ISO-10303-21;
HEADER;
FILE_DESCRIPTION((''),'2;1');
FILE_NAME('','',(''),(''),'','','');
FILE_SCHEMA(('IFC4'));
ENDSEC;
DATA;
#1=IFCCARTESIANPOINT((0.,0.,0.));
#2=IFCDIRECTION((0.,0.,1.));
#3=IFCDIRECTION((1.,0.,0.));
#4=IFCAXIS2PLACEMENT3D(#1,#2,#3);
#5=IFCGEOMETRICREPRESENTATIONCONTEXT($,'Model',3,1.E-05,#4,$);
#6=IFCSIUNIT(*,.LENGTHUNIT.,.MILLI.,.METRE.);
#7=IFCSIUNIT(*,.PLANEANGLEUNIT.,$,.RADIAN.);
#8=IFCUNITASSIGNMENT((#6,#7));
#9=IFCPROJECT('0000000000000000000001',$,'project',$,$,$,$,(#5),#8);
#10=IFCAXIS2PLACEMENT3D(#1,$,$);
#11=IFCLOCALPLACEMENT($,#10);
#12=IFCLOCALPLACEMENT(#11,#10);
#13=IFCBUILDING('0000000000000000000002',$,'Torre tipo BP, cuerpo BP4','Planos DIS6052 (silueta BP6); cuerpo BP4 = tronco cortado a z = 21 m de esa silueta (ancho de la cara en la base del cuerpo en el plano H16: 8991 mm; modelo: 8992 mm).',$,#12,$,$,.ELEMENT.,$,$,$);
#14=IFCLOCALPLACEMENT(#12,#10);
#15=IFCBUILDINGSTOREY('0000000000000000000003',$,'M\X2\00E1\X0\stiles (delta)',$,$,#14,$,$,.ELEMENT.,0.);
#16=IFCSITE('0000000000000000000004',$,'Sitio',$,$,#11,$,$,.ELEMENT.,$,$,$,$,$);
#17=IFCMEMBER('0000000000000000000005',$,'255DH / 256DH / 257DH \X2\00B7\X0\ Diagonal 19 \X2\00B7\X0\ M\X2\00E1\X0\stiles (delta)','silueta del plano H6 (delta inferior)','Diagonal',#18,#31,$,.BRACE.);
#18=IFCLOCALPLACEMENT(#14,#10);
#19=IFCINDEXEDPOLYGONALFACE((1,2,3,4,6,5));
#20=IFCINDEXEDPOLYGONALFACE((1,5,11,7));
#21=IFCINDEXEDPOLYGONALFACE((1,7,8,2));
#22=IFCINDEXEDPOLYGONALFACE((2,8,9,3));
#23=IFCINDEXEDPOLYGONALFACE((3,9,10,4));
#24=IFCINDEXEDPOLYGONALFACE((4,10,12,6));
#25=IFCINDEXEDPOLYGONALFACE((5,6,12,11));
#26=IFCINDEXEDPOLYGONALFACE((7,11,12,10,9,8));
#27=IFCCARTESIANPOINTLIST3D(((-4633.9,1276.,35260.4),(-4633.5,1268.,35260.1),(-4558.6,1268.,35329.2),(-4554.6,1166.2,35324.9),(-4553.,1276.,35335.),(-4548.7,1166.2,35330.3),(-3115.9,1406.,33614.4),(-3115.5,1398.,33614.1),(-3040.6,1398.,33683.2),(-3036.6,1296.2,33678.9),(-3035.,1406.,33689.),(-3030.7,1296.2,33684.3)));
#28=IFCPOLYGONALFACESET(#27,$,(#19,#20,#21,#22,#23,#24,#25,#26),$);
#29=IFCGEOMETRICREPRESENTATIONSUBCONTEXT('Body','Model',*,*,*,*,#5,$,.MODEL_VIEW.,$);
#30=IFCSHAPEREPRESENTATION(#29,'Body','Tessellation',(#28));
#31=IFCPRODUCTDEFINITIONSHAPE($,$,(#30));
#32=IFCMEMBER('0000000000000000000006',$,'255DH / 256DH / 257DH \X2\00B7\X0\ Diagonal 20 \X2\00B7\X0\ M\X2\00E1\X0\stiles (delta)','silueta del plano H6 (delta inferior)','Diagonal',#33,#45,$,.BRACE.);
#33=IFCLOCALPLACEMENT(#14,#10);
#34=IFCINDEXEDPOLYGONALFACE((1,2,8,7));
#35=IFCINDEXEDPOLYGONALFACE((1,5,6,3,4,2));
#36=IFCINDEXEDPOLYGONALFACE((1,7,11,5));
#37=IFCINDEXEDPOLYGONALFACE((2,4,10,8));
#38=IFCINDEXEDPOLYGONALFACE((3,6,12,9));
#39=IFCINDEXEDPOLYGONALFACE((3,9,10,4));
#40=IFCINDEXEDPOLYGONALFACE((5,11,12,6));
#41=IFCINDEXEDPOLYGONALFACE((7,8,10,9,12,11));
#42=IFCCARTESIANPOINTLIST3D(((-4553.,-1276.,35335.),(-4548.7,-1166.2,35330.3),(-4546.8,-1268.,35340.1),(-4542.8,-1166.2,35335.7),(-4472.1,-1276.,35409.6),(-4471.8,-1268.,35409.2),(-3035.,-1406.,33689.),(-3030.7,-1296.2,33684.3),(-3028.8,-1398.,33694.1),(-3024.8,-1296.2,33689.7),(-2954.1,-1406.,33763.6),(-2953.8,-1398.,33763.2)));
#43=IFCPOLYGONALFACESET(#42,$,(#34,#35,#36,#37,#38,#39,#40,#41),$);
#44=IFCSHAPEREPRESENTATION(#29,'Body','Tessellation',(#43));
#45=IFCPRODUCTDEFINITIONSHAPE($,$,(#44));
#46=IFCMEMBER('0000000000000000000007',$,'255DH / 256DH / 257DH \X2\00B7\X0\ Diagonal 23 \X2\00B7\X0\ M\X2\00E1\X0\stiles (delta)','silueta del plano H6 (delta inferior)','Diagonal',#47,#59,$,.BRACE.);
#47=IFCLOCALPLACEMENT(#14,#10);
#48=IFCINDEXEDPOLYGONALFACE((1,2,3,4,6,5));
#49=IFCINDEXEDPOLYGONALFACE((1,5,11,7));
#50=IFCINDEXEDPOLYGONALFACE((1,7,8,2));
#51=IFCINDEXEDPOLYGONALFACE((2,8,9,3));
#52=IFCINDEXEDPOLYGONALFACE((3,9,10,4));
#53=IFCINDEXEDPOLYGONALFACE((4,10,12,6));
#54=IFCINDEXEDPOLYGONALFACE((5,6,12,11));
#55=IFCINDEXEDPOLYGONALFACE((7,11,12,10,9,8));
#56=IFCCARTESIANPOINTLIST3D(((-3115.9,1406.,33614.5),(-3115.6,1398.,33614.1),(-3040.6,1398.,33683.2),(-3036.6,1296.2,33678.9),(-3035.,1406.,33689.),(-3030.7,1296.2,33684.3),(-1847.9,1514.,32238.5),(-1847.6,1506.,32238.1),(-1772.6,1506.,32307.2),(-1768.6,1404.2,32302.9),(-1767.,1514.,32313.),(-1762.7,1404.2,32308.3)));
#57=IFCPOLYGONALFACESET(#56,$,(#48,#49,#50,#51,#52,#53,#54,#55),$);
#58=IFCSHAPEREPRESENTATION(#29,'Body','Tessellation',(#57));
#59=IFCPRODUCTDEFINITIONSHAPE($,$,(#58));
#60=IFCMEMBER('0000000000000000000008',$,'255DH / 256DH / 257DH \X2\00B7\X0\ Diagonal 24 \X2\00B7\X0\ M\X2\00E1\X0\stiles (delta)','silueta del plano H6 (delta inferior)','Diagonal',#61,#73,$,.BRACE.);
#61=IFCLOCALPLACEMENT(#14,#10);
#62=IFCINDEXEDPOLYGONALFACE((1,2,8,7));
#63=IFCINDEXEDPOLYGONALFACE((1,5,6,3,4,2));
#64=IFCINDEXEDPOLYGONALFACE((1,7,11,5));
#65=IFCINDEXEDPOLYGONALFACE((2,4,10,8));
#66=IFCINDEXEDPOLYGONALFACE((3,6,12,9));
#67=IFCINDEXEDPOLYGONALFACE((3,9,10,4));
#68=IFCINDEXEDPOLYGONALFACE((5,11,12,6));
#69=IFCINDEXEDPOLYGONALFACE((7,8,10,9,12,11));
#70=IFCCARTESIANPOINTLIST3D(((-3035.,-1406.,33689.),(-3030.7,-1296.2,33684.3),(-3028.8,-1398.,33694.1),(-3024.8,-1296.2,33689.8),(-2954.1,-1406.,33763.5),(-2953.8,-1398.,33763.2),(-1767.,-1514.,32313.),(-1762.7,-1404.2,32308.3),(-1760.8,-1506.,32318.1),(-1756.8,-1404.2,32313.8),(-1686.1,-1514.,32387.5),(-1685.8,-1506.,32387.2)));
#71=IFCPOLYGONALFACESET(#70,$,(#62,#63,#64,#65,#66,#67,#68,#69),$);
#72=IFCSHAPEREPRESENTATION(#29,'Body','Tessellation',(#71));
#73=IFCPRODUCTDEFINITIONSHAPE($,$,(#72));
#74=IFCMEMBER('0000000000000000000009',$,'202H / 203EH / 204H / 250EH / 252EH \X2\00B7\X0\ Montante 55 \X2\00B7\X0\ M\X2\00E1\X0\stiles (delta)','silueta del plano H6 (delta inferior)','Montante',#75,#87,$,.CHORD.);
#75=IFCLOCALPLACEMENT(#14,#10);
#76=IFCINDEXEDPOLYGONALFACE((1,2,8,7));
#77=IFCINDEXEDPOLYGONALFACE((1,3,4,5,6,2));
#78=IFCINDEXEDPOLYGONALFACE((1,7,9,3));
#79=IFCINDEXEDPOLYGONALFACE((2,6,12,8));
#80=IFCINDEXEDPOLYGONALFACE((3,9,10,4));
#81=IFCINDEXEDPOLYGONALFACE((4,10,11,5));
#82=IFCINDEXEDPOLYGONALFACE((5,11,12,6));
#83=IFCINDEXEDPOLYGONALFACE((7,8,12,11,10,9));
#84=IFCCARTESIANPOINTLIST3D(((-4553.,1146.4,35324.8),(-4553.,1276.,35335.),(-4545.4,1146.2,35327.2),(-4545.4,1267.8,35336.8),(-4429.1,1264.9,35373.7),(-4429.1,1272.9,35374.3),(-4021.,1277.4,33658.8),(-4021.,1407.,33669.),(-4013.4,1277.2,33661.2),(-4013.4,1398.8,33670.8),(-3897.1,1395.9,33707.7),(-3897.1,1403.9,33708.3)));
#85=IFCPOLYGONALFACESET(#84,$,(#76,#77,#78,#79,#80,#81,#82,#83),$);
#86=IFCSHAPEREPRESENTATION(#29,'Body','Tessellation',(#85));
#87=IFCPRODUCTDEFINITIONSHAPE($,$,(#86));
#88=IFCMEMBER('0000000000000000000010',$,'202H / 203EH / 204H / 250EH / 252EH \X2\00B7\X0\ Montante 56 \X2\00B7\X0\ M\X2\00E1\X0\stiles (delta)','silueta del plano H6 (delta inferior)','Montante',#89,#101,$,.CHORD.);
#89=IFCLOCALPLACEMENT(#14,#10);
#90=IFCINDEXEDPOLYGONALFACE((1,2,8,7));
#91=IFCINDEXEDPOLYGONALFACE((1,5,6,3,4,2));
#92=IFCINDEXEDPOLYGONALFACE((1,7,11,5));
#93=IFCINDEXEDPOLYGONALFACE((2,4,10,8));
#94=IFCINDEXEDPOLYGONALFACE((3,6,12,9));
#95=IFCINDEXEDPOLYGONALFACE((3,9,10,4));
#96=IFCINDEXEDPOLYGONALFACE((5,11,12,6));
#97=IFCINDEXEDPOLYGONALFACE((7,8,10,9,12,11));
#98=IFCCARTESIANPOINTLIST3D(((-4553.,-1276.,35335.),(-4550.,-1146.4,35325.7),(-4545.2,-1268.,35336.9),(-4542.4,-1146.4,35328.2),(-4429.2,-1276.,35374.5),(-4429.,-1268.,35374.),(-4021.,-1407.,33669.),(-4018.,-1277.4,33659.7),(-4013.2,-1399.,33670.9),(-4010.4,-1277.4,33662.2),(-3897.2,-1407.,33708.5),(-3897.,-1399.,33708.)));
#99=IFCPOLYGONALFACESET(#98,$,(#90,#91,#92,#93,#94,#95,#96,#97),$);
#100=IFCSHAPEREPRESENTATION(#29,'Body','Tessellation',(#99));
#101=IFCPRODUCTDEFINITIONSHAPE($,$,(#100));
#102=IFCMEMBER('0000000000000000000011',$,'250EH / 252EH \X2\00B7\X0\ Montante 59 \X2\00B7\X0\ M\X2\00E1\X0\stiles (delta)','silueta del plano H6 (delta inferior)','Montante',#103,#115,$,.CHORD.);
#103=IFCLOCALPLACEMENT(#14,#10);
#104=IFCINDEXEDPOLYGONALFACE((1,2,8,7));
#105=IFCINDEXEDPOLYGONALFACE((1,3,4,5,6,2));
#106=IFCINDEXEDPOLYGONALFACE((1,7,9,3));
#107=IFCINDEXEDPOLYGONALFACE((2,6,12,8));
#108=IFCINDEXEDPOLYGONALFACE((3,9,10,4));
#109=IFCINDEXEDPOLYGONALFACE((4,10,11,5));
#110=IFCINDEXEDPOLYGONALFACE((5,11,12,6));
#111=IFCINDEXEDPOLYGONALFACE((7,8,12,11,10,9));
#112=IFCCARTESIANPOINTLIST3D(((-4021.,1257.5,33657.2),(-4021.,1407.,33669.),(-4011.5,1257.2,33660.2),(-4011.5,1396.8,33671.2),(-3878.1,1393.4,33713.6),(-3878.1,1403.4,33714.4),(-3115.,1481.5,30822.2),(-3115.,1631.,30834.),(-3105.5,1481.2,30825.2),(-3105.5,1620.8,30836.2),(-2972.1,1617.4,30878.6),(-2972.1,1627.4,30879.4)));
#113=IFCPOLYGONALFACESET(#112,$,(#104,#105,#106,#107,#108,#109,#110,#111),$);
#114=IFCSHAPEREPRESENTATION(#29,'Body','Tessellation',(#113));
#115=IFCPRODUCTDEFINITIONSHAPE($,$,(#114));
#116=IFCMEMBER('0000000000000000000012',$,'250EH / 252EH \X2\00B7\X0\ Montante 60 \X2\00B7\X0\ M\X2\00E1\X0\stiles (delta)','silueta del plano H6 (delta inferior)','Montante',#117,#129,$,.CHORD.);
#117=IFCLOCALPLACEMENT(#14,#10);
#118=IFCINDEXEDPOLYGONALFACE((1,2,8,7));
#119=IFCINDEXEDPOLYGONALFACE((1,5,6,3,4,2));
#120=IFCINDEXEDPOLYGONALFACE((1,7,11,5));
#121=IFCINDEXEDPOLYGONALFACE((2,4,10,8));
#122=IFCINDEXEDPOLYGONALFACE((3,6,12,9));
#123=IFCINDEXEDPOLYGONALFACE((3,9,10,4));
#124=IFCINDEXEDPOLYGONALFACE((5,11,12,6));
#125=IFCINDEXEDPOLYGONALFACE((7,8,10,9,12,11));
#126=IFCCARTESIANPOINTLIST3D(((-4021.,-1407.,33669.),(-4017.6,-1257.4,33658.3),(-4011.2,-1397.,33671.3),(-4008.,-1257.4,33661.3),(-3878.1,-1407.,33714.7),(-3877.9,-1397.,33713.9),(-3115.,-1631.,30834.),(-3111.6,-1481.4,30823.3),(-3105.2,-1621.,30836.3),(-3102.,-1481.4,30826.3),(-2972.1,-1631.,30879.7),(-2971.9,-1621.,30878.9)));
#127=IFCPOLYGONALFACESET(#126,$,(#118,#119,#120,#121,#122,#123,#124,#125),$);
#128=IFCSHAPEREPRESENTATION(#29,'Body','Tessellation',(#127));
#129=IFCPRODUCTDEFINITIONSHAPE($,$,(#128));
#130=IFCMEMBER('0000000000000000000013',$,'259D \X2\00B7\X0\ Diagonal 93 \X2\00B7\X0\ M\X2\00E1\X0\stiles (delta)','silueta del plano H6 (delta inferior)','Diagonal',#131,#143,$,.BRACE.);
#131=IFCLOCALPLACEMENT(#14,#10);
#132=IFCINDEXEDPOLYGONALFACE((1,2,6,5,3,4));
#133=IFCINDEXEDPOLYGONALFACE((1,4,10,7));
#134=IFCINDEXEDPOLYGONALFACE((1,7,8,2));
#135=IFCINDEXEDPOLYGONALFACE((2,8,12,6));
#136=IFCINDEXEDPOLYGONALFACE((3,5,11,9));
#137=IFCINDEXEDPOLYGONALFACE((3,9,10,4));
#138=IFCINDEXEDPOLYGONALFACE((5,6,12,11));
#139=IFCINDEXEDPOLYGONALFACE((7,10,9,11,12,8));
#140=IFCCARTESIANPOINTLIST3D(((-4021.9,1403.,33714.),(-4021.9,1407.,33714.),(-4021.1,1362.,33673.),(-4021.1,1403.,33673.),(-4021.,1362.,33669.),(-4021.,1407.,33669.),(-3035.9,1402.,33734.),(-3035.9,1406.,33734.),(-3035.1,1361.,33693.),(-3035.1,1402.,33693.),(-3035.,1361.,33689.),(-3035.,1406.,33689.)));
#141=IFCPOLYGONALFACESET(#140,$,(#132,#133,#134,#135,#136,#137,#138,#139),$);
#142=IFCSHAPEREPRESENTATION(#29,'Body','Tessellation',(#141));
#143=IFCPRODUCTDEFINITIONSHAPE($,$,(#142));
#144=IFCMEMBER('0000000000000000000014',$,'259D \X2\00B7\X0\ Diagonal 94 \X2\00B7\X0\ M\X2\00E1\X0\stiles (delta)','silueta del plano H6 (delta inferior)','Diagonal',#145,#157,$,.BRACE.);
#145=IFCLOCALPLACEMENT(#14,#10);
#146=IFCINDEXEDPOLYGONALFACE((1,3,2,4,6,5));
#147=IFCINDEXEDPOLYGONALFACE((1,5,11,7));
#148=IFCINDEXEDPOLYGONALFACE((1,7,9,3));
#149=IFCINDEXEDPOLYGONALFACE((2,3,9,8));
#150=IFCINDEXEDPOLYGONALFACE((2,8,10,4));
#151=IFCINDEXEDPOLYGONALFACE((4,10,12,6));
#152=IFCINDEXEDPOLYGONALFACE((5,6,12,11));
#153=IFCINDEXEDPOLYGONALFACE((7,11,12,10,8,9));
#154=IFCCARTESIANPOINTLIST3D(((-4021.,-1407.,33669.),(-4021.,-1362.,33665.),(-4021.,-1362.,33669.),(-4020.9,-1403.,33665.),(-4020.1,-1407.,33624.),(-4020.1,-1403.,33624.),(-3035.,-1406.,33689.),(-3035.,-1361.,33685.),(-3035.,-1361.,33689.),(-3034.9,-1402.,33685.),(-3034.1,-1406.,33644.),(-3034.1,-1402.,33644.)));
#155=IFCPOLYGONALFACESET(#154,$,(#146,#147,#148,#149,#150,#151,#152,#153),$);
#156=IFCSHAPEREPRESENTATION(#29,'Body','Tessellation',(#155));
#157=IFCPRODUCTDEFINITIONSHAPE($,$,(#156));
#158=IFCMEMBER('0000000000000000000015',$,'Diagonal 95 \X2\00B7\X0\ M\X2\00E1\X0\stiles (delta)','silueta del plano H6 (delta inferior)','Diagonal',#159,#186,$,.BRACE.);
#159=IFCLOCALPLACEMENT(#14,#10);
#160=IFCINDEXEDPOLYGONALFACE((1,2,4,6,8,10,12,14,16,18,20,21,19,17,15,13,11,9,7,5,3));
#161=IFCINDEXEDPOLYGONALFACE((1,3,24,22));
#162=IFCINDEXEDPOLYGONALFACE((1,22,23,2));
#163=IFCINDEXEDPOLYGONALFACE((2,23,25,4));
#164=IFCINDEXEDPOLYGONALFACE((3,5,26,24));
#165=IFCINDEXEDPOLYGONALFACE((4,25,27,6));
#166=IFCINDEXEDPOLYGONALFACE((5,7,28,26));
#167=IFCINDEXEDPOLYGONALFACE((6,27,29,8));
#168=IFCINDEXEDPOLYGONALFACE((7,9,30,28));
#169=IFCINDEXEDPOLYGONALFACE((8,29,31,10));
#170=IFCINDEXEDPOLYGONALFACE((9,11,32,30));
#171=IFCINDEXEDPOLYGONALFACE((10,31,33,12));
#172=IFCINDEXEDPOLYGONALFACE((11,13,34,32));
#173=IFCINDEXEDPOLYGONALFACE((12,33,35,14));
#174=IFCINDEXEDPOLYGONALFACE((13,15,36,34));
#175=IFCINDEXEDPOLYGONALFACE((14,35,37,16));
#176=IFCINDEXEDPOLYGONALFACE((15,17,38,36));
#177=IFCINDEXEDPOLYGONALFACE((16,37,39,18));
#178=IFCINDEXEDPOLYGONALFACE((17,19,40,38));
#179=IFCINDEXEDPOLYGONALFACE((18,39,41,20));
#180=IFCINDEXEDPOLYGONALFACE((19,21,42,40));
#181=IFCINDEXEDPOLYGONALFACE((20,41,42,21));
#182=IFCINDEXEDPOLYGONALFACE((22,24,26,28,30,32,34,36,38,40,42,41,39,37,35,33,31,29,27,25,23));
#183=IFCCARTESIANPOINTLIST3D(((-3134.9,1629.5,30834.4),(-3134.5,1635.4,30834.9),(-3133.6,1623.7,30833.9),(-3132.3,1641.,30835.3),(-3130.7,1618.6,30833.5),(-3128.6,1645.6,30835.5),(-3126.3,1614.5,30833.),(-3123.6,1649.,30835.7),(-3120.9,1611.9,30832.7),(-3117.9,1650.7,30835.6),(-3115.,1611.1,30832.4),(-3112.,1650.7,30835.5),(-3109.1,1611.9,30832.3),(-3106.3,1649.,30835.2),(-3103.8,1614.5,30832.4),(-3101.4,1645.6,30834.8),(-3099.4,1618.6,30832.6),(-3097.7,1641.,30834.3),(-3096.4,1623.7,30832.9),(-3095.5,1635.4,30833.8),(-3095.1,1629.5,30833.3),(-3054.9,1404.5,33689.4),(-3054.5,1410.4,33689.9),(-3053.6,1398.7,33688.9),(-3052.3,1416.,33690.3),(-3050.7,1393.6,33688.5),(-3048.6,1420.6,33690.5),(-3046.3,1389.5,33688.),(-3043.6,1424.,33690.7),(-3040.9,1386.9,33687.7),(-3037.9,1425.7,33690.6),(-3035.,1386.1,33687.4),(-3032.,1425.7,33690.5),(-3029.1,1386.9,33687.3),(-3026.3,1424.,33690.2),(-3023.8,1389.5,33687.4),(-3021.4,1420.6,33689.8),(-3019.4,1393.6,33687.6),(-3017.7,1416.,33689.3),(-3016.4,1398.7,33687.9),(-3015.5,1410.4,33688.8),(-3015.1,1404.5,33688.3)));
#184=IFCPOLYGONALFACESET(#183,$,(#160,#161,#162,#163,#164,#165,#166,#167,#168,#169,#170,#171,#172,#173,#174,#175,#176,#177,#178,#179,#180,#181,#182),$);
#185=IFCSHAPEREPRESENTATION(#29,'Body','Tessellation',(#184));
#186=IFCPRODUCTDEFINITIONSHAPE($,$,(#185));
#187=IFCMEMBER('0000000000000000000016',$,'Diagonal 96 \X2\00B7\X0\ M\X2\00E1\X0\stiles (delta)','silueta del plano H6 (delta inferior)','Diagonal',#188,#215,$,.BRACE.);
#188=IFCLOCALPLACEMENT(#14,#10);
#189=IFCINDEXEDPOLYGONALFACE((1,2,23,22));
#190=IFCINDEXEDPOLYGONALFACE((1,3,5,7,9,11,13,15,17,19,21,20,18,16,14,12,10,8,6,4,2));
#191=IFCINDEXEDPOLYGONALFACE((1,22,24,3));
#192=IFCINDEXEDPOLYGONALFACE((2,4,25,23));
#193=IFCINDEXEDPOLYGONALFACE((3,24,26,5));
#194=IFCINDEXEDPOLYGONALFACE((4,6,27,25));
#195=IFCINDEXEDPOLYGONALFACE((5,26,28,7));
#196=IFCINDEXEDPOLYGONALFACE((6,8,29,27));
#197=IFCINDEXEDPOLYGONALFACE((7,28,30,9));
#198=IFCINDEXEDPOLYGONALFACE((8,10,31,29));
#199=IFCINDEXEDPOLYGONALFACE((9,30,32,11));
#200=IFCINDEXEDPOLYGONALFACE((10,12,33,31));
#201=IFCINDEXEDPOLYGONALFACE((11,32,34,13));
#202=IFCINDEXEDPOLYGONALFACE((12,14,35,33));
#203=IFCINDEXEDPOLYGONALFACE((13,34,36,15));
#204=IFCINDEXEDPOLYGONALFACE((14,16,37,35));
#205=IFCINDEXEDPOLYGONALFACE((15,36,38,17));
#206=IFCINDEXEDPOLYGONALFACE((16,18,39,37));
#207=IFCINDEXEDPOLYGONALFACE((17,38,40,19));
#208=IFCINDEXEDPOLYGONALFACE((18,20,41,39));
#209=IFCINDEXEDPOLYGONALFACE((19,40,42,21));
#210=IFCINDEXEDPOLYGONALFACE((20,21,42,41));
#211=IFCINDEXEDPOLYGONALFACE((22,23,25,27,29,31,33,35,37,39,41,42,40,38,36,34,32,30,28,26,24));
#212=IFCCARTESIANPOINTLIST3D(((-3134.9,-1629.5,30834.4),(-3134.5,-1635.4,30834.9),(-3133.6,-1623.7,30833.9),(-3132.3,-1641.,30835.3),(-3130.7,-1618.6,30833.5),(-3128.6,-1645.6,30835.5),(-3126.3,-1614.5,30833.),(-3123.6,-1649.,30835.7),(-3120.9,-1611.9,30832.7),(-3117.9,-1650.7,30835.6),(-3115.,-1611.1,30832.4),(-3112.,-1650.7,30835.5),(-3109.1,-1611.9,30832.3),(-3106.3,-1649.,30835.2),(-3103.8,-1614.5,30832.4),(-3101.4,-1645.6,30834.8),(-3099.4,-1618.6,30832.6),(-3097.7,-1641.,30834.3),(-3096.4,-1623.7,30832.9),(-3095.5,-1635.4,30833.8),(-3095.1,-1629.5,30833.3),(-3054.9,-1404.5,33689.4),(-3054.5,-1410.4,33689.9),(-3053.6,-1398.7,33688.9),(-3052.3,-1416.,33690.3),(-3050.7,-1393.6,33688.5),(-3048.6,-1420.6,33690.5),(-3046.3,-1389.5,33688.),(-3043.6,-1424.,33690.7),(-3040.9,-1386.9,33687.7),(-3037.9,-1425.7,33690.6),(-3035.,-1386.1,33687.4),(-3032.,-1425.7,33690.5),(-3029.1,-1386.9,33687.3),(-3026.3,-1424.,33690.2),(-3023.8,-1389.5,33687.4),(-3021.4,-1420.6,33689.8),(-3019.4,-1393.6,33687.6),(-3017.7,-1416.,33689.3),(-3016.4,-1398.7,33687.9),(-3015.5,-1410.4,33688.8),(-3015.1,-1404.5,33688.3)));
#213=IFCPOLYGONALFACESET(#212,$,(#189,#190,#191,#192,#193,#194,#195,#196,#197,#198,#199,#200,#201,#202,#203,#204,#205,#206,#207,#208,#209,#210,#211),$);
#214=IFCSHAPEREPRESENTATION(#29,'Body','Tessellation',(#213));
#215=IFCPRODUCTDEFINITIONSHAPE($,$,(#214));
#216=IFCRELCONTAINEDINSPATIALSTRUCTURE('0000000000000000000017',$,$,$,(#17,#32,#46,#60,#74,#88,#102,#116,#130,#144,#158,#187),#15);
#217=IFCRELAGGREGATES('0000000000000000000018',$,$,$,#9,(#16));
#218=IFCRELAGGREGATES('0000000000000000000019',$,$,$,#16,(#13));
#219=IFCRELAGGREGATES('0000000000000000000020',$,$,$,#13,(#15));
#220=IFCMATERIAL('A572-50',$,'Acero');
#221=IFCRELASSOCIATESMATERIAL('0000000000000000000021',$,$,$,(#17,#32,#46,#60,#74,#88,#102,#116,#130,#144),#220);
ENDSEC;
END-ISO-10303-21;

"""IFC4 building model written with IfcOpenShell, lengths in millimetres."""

from ifc_helpers import new_model, si_unit, frame, frame_2d, origin, origin_with_axes, place, context, subcontext, project, spatial, circle, l_section, extrude, material, element, save


model = new_model("IFC4")

# Units and contexts
model_context = context("Model", 3, precision=1e-05, world=origin_with_axes())
body_context = subcontext(model_context, "Body", "Model", "MODEL_VIEW")
ifc_project = project(units=[si_unit("LENGTHUNIT", "METRE", prefix="MILLI"), si_unit("PLANEANGLEUNIT", "RADIAN")], contexts=[model_context])

# Site, building, storey
site_placement = place(None, origin())
site = spatial("IfcSite", under=ifc_project, at=site_placement, Name="Sitio", CompositionType="ELEMENT")
building_placement = place(site_placement, origin())
building = spatial("IfcBuilding", under=site, at=building_placement, Name="Torre tipo BP, cuerpo BP4", Description="Planos DIS6052 (silueta BP6); cuerpo BP4 = tronco cortado a z = 21 m de esa silueta (ancho de la cara en la base del cuerpo en el plano H16: 8991 mm; modelo: 8992 mm).", CompositionType="ELEMENT")
storey_placement = place(building_placement, origin())
storey = spatial("IfcBuildingStorey", under=building, at=storey_placement, Name="Mástiles (delta)", CompositionType="ELEMENT", Elevation=0.0)

# Members
ifc_material = material(Name="A572-50", Category="Acero")
for number, where, z_axis, x_axis, name in (
    (1, (-4553.0, 1276.0, 35335.0), (0.676806, 0.057961, -0.733876), (0.039294, -0.998319, -0.042608), "255DH / 256DH / 257DH · Diagonal 19 · Mástiles (delta)"),
    (2, (-4553.0, -1276.0, 35335.0), (0.676806, -0.057961, -0.733876), (0.039294, 0.998319, -0.042608), "255DH / 256DH / 257DH · Diagonal 20 · Mástiles (delta)"),
):
    element("IfcMember", number, at=place(storey_placement, frame(where, z_axis=z_axis, x_axis=x_axis)), inside=storey, material=ifc_material, Name=name, Description="silueta del plano H6 (delta inferior)", ObjectType="Diagonal", PredefinedType="BRACE", context=body_context, shape_type="SweptSolid", body=[
        extrude(l_section(Depth=110.0, Width=110.0, Thickness=8.0, at=frame_2d((55.0, 55.0))), None, (0.0, 0.0, 1.0), 2242.9),
    ])
for number, where, z_axis, x_axis, name in (
    (3, (-3035.0, 1406.0, 33689.0), (0.676532, 0.057623, -0.734155), (0.039048, -0.998338, -0.042374), "255DH / 256DH / 257DH · Diagonal 23 · Mástiles (delta)"),
    (4, (-3035.0, -1406.0, 33689.0), (0.676532, -0.057623, -0.734155), (0.039048, 0.998338, -0.042374), "255DH / 256DH / 257DH · Diagonal 24 · Mástiles (delta)"),
):
    element("IfcMember", number, at=place(storey_placement, frame(where, z_axis=z_axis, x_axis=x_axis)), inside=storey, material=ifc_material, Name=name, Description="silueta del plano H6 (delta inferior)", ObjectType="Diagonal", PredefinedType="BRACE", context=body_context, shape_type="SweptSolid", body=[
        extrude(l_section(Depth=110.0, Width=110.0, Thickness=8.0, at=frame_2d((55.0, 55.0))), None, (0.0, 0.0, 1.0), 1874.3),
    ])
for number, where, z_axis, x_axis, name in (
    (5, (-4553.0, 1276.0, 35335.0), (0.303345, 0.074696, -0.949949), (0.952881, -0.023779, 0.302411), "202H / 203EH / 204H / 250EH / 252EH · Montante 55 · Mástiles (delta)"),
    (6, (-4553.0, -1276.0, 35335.0), (0.303345, -0.074696, -0.949949), (0.022722, 0.997206, -0.071156), "202H / 203EH / 204H / 250EH / 252EH · Montante 56 · Mástiles (delta)"),
):
    element("IfcMember", number, at=place(storey_placement, frame(where, z_axis=z_axis, x_axis=x_axis)), inside=storey, material=ifc_material, Name=name, Description="silueta del plano H6 (delta inferior)", ObjectType="Montante", PredefinedType="CHORD", context=body_context, shape_type="SweptSolid", body=[
        extrude(l_section(Depth=130.0, Width=130.0, Thickness=8.0, at=frame_2d((65.0, 65.0))), None, (0.0, 0.0, 1.0), 1753.8),
    ])
for number, where, z_axis, x_axis, name in (
    (7, (-4021.0, 1407.0, 33669.0), (0.303551, 0.07505, -0.949855), (0.952815, -0.02391, 0.302608), "250EH / 252EH · Montante 59 · Mástiles (delta)"),
    (8, (-4021.0, -1407.0, 33669.0), (0.303551, -0.07505, -0.949855), (0.022846, 0.99718, -0.071488), "250EH / 252EH · Montante 60 · Mástiles (delta)"),
):
    element("IfcMember", number, at=place(storey_placement, frame(where, z_axis=z_axis, x_axis=x_axis)), inside=storey, material=ifc_material, Name=name, Description="silueta del plano H6 (delta inferior)", ObjectType="Montante", PredefinedType="CHORD", context=body_context, shape_type="SweptSolid", body=[
        extrude(l_section(Depth=150.0, Width=150.0, Thickness=10.0, at=frame_2d((75.0, 75.0))), None, (0.0, 0.0, 1.0), 2984.7),
    ])
for number, where, z_axis, x_axis, name in (
    (9, (-3035.0, 1406.0, 33689.0), (-0.999794, 0.001014, -0.02028), (-0.001014, -0.999999, -0.000021), "259D · Diagonal 93 · Mástiles (delta)"),
    (10, (-3035.0, -1406.0, 33689.0), (-0.999794, -0.001014, -0.02028), (-0.001014, 0.999999, -0.000021), "259D · Diagonal 94 · Mástiles (delta)"),
):
    element("IfcMember", number, at=place(storey_placement, frame(where, z_axis=z_axis, x_axis=x_axis)), inside=storey, material=ifc_material, Name=name, Description="silueta del plano H6 (delta inferior)", ObjectType="Diagonal", PredefinedType="BRACE", context=body_context, shape_type="SweptSolid", body=[
        extrude(l_section(Depth=45.0, Width=45.0, Thickness=4.0, at=frame_2d((22.5, 22.5))), None, (0.0, 0.0, 1.0), 986.2),
    ])
for number, where, z_axis, x_axis, name in (
    (11, (-3035.0, 1406.0, 33689.0), (-0.027924, 0.078535, -0.99652), (-0.0022, -0.996911, -0.078504), "Diagonal 95 · Mástiles (delta)"),
    (12, (-3035.0, -1406.0, 33689.0), (-0.027924, -0.078535, -0.99652), (-0.0022, 0.996911, -0.078504), "Diagonal 96 · Mástiles (delta)"),
):
    element("IfcMember", number, at=place(storey_placement, frame(where, z_axis=z_axis, x_axis=x_axis)), inside=storey, Name=name, Description="silueta del plano H6 (delta inferior)", ObjectType="Diagonal", PredefinedType="BRACE", context=body_context, shape_type="SweptSolid", body=[
        extrude(circle(Radius=20.0), None, (0.0, 0.0, 1.0), 2865.0),
    ])

save(model, "model.ifc")
